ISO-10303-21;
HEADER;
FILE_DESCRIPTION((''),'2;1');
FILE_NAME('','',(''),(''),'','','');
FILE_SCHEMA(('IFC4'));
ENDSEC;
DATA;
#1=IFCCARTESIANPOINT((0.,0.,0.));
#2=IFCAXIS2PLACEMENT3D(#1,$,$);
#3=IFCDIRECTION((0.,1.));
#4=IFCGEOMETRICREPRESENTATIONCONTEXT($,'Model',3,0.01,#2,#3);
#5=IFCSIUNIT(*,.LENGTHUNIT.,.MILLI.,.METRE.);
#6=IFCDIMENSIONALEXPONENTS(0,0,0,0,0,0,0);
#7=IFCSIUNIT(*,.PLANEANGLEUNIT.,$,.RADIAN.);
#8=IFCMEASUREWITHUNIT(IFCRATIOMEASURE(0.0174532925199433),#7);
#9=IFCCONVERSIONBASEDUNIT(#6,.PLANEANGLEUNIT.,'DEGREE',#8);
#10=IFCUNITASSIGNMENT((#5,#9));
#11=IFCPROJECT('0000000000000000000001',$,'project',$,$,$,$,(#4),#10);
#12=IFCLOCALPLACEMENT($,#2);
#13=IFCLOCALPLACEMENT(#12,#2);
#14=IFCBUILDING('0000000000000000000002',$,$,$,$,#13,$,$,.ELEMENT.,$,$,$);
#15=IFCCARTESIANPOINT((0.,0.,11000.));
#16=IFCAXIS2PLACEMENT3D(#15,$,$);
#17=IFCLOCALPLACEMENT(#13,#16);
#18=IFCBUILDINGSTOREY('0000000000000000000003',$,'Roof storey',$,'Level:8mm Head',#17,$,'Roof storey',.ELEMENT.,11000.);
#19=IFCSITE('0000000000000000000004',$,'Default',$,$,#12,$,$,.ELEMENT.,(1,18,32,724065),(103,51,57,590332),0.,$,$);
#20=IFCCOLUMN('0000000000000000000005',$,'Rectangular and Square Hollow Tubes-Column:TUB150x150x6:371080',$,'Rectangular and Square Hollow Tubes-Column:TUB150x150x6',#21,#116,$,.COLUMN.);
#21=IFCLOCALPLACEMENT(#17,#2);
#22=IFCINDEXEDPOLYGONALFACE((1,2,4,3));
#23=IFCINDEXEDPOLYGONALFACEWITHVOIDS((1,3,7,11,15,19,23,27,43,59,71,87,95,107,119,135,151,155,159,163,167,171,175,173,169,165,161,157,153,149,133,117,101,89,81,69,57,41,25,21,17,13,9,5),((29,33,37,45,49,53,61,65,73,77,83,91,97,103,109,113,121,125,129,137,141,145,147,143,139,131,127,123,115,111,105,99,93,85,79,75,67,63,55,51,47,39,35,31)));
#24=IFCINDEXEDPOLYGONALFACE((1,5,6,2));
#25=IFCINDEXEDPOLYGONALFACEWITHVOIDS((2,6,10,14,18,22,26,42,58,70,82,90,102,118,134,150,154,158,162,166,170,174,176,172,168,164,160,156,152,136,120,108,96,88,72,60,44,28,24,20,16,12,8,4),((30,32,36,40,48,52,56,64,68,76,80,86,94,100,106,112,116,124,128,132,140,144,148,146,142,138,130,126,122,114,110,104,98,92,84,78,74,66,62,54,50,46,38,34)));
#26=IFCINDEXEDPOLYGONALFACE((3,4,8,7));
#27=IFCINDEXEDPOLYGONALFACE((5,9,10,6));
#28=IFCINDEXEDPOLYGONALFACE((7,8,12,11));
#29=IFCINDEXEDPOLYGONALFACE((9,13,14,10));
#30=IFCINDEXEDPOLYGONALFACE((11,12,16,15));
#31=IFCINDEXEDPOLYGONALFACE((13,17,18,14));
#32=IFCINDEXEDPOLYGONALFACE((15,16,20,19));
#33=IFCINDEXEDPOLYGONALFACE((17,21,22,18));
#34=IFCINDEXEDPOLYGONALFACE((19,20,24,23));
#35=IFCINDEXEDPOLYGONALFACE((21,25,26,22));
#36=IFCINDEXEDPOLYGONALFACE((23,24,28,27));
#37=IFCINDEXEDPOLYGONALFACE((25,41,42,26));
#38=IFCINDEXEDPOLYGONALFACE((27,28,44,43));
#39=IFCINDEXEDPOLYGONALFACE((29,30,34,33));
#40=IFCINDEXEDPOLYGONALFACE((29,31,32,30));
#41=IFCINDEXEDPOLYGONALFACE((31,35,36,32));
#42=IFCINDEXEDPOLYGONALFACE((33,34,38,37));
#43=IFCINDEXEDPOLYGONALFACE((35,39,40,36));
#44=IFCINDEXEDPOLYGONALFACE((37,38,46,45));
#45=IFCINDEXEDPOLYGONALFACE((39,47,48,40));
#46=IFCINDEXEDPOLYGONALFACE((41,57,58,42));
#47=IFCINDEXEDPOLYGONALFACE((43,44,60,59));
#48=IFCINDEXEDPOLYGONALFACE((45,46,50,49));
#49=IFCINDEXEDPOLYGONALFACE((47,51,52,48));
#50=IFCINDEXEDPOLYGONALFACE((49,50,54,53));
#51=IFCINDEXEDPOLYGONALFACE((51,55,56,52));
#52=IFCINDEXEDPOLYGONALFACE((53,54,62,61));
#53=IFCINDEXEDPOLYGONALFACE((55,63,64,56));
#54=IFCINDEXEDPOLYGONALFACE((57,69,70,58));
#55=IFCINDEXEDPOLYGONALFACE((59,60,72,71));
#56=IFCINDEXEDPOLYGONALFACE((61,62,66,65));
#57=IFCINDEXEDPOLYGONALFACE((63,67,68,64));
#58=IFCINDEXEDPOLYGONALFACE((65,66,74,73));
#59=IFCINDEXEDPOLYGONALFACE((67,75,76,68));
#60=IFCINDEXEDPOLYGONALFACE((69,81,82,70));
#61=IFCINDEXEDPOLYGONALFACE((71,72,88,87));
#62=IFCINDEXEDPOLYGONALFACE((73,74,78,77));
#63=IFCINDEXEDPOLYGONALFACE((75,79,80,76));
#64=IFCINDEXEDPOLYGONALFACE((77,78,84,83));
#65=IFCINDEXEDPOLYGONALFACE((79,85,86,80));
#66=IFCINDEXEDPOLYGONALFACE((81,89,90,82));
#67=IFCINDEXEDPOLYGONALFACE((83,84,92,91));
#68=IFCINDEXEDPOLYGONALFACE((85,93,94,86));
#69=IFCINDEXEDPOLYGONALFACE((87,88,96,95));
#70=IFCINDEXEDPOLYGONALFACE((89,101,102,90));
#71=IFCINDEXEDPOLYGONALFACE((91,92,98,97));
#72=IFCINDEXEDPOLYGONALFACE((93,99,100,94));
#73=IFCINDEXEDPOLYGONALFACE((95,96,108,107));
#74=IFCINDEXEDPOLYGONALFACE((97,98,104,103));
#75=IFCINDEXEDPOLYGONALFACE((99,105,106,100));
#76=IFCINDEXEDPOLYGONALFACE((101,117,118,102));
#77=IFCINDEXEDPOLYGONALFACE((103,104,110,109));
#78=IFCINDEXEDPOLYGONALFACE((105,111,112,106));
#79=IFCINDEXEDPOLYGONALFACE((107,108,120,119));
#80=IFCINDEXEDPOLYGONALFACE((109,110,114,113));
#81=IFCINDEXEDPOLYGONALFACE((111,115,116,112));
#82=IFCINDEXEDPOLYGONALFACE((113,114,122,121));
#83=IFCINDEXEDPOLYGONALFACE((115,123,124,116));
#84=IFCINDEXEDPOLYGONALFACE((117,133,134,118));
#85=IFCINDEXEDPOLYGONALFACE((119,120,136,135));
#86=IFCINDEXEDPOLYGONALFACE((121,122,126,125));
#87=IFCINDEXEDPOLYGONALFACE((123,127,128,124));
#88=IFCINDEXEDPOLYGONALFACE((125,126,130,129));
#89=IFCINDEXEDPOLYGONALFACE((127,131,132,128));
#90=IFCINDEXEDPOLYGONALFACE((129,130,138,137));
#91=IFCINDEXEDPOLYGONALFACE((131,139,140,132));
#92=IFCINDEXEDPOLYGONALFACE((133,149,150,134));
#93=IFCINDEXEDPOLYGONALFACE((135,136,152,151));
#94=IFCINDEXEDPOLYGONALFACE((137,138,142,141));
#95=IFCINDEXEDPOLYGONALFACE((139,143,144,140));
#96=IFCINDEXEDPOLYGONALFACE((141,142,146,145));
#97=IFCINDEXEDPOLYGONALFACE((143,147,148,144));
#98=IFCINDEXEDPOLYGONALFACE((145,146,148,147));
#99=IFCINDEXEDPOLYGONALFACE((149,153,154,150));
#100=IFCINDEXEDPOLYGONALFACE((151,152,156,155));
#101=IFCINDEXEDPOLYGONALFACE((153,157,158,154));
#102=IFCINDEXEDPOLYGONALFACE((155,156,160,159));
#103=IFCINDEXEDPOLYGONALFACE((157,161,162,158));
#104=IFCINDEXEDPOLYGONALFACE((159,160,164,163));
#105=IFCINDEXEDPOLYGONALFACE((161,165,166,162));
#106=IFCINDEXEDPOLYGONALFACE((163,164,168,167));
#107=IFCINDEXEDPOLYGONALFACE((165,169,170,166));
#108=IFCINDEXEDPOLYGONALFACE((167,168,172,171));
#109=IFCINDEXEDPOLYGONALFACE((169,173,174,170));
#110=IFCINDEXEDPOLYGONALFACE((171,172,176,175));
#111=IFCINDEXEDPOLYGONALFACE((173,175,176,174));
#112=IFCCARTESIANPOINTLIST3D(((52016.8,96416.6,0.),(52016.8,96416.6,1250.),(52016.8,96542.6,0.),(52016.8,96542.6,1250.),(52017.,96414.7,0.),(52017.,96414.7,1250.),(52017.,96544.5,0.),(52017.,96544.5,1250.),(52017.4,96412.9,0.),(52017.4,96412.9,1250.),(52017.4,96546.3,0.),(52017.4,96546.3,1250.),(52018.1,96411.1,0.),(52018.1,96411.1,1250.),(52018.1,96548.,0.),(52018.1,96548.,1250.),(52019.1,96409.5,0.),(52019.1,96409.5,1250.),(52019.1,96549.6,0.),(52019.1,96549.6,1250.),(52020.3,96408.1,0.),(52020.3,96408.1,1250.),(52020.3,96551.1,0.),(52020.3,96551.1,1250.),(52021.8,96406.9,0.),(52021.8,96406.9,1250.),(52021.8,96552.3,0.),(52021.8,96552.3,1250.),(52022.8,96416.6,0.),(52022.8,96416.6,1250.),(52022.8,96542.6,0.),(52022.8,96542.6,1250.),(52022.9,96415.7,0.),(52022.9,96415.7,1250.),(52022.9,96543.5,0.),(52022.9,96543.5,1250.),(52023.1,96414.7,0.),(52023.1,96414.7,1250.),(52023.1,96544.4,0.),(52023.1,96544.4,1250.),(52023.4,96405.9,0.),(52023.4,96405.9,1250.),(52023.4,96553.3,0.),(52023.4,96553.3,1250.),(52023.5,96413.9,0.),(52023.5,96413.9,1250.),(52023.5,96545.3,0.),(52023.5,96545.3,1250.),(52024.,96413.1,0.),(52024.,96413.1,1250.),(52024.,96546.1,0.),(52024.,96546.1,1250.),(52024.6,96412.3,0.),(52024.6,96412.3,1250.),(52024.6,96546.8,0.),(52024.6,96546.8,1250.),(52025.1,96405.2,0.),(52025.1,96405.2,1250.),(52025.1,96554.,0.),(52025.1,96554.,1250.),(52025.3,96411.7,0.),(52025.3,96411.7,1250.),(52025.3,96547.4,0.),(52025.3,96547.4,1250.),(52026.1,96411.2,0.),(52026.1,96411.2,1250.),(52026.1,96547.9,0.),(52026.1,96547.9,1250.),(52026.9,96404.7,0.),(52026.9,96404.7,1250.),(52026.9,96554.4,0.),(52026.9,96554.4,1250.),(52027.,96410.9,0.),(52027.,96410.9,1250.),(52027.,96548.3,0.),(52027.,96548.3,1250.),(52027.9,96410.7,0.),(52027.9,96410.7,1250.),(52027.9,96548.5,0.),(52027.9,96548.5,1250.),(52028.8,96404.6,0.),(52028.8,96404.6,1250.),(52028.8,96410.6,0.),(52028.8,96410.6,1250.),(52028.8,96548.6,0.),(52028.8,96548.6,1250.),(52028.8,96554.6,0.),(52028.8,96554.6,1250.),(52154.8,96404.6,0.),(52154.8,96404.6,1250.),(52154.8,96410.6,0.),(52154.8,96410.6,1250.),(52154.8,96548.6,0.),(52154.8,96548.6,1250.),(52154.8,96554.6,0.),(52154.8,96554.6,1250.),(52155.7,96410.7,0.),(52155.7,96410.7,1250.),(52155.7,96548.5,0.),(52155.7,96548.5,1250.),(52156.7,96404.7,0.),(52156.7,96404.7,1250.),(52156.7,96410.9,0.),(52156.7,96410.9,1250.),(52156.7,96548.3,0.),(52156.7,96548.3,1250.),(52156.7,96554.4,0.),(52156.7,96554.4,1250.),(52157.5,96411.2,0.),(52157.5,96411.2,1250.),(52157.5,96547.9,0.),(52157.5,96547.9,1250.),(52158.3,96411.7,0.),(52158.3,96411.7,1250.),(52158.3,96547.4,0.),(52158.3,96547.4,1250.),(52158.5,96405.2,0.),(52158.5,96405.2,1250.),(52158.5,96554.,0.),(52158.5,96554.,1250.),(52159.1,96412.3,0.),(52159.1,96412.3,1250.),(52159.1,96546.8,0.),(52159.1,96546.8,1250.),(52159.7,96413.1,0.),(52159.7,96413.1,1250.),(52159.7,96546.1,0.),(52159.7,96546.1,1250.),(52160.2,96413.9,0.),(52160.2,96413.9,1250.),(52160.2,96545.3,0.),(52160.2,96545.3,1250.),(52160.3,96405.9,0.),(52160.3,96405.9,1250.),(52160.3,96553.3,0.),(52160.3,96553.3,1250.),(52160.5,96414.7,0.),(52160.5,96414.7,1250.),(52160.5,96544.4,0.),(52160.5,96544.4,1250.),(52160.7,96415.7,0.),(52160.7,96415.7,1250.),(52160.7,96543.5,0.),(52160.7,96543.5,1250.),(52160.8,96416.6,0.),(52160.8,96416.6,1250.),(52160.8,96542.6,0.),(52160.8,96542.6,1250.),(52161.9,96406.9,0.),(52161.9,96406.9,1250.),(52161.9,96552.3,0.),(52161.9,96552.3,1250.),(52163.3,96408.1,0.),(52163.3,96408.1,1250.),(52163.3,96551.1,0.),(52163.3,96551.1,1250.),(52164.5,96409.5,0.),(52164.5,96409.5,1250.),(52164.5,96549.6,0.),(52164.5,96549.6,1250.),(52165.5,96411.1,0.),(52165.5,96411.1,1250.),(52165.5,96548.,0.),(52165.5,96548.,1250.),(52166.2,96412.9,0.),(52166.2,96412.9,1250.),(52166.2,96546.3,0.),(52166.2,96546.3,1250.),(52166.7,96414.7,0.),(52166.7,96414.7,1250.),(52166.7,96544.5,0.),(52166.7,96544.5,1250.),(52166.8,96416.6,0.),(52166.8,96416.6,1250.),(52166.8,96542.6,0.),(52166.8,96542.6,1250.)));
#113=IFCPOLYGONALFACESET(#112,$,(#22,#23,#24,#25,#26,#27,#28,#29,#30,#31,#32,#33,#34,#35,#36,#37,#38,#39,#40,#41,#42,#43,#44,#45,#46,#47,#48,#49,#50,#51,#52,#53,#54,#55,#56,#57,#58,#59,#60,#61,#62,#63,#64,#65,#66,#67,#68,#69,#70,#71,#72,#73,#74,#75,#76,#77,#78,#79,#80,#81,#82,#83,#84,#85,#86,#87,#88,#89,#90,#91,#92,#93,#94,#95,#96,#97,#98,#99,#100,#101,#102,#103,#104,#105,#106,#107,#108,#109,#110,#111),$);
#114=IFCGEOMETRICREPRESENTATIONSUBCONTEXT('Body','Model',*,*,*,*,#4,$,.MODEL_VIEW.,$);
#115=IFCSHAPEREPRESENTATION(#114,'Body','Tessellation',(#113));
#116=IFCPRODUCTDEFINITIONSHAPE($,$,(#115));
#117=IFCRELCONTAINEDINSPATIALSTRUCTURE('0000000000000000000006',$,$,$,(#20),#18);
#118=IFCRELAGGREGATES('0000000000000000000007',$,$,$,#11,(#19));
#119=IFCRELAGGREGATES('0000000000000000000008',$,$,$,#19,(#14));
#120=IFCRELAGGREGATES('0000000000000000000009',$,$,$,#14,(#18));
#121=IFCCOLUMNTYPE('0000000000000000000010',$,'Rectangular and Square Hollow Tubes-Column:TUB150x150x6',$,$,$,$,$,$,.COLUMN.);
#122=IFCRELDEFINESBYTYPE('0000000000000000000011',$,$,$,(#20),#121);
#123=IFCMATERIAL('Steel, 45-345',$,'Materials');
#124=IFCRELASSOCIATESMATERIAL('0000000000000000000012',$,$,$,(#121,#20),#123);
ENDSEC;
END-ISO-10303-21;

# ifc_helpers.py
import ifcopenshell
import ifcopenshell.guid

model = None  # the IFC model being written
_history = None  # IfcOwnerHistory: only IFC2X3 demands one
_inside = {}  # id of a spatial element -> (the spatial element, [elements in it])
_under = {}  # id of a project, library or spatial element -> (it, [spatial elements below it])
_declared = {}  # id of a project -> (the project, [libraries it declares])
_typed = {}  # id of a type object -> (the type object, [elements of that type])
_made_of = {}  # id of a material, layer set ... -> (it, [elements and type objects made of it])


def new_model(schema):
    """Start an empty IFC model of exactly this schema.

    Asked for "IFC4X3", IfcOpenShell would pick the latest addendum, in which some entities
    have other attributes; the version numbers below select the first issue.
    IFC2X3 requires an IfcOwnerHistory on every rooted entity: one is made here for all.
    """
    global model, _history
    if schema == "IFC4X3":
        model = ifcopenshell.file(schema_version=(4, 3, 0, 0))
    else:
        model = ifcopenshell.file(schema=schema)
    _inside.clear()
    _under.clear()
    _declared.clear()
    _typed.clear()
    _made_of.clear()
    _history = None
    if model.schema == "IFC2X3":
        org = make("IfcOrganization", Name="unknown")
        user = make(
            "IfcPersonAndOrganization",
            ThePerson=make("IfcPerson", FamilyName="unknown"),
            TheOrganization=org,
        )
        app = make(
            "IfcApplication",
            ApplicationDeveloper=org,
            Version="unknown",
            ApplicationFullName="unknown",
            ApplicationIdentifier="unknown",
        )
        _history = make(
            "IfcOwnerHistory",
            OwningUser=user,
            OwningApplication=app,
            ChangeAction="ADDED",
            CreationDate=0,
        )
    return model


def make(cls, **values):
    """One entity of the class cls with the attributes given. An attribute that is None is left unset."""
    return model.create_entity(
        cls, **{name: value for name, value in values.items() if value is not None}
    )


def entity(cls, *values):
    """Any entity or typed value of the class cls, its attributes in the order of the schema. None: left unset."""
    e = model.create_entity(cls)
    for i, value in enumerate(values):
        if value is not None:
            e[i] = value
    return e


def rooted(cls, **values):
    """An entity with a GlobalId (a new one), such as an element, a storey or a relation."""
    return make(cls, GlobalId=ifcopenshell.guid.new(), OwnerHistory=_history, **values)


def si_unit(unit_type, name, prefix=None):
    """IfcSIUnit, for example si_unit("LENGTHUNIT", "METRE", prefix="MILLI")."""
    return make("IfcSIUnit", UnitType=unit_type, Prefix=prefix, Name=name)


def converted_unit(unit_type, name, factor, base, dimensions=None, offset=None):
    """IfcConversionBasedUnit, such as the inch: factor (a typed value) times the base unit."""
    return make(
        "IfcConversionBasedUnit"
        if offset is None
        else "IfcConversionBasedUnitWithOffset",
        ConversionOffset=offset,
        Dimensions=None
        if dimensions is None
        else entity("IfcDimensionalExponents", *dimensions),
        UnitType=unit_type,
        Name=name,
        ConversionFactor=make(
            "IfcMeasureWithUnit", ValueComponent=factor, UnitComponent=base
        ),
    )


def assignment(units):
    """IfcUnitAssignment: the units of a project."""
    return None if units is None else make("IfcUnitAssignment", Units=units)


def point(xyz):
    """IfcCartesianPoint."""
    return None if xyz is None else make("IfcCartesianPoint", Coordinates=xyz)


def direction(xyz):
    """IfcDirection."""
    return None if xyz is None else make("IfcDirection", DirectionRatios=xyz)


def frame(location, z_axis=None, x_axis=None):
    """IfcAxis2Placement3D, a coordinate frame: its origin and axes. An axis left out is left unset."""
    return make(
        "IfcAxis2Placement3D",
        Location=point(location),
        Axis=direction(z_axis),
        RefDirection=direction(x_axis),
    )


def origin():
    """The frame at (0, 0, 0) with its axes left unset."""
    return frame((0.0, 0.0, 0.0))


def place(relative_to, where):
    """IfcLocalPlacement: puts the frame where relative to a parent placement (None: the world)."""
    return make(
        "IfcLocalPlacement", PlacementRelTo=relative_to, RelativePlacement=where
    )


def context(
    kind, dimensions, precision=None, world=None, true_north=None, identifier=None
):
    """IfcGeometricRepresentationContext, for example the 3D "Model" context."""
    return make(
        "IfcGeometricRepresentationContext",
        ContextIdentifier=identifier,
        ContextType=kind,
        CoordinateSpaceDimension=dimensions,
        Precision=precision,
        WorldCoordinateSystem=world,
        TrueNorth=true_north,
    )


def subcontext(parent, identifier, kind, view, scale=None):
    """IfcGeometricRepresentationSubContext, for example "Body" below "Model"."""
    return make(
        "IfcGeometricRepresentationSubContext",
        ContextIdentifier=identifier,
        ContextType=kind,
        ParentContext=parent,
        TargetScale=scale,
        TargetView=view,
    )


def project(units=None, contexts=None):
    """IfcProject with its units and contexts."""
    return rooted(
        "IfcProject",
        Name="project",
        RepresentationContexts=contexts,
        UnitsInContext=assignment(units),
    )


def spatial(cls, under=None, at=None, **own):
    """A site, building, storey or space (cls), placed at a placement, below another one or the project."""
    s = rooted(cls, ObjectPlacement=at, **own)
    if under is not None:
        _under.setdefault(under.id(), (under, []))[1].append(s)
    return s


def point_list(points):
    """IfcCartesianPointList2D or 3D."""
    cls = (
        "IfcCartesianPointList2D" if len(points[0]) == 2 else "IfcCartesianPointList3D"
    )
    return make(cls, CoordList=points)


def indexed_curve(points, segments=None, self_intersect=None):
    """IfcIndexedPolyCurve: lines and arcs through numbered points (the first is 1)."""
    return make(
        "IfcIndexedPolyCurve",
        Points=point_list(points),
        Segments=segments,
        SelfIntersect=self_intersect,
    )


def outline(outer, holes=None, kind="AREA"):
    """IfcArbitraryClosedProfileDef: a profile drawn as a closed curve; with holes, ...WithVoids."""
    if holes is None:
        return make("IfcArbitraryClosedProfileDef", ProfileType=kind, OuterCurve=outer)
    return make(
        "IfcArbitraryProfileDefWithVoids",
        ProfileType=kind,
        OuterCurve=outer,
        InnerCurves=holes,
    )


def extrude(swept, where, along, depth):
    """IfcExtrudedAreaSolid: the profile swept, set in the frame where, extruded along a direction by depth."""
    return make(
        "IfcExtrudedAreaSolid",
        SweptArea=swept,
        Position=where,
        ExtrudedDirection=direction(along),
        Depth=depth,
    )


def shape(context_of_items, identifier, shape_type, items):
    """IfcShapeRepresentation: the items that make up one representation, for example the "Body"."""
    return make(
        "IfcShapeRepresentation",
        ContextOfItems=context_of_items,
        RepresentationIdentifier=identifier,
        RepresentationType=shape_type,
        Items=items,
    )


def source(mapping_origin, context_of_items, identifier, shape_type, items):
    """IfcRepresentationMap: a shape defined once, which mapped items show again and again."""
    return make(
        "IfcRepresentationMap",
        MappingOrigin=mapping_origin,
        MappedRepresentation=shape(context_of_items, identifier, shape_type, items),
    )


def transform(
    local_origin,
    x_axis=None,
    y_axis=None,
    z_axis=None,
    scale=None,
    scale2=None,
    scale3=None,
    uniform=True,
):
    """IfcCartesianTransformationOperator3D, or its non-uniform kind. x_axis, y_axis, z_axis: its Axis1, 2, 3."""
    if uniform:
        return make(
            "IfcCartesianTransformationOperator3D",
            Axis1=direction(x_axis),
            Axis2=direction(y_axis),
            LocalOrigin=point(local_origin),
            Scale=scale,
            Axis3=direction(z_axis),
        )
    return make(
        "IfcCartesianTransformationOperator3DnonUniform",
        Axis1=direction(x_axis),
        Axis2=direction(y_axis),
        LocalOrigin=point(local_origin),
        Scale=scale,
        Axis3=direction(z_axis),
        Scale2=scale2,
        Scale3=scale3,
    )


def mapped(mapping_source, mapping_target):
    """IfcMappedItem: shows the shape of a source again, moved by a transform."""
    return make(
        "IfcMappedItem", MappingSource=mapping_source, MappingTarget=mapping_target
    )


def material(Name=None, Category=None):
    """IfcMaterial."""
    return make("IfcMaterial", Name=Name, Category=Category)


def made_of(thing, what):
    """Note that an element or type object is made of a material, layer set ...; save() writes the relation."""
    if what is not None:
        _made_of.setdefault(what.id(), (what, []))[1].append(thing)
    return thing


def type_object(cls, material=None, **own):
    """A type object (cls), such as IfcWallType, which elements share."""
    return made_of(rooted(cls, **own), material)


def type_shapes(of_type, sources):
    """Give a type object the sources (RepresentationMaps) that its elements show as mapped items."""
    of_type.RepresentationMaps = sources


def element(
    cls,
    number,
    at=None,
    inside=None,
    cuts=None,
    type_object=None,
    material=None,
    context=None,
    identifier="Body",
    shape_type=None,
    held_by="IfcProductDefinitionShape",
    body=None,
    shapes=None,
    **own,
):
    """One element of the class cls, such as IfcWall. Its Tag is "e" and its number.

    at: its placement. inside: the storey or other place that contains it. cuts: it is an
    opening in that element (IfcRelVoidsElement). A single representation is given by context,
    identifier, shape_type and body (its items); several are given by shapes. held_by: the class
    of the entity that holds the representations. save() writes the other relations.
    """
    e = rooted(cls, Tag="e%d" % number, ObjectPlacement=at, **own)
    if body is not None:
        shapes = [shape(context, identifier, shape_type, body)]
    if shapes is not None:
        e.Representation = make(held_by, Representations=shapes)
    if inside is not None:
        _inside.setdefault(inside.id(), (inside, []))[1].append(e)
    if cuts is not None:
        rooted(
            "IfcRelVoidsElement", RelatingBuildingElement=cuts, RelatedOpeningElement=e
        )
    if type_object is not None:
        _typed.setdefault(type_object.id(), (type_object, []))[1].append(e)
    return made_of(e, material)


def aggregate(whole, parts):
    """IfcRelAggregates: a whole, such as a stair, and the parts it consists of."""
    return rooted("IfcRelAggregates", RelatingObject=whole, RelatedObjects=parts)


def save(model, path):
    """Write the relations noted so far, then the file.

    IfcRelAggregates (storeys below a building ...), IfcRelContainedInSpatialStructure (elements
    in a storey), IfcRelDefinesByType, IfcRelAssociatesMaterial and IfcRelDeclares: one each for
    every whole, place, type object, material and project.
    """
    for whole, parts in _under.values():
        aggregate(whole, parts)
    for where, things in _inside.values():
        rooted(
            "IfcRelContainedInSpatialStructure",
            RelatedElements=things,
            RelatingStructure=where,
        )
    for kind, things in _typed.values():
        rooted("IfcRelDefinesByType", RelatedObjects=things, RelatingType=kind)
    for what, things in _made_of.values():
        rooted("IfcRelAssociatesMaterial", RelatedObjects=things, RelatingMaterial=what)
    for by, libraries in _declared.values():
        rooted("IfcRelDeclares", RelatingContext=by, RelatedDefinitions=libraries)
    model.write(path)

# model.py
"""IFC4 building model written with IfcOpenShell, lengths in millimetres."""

from ifc_helpers import new_model, entity, si_unit, converted_unit, direction, frame, origin, place, context, subcontext, project, spatial, indexed_curve, outline, extrude, source, transform, mapped, material, type_object, type_shapes, element, save


model = new_model("IFC4")

# Units and contexts
model_context = context("Model", 3, precision=0.01, world=origin(), true_north=direction((0.0, 1.0)))
body_context = subcontext(model_context, "Body", "Model", "MODEL_VIEW")
ifc_project = project(units=[si_unit("LENGTHUNIT", "METRE", prefix="MILLI"), converted_unit("PLANEANGLEUNIT", "DEGREE", entity("IfcRatioMeasure", 0.0174532925199433), si_unit("PLANEANGLEUNIT", "RADIAN"), dimensions=[0, 0, 0, 0, 0, 0, 0])], contexts=[model_context])

# Site, building, storey
site_placement = place(None, origin())
site = spatial("IfcSite", under=ifc_project, at=site_placement, Name="Default", CompositionType="ELEMENT", RefLatitude=(1, 18, 32, 724065), RefLongitude=(103, 51, 57, 590332), RefElevation=0.0)
building_placement = place(site_placement, origin())
building = spatial("IfcBuilding", under=site, at=building_placement, CompositionType="ELEMENT")
storey_placement = place(building_placement, frame((0.0, 0.0, 11000.0)))
storey = spatial("IfcBuildingStorey", under=building, at=storey_placement, Name="Roof storey", ObjectType="Level:8mm Head", LongName="Roof storey", CompositionType="ELEMENT", Elevation=11000.0)

# Column
ifc_material = material(Name="Steel, 45-345", Category="Materials")
column_type = type_object("IfcColumnType", Name="Rectangular and Square Hollow Tubes-Column:TUB150x150x6", PredefinedType="COLUMN", material=ifc_material)
shared_shape_1 = source(origin(), body_context, "Body", "SweptSolid", [
    extrude(outline(indexed_curve([(-63.0, -75.0), (63.0, -75.0), (64.9, -74.9), (66.7, -74.4), (68.4, -73.7), (70.1, -72.7), (71.5, -71.5), (72.7, -70.1), (73.7, -68.4), (74.4, -66.7), (74.9, -64.9), (75.0, -63.0), (75.0, 63.0), (74.9, 64.9), (74.4, 66.7), (73.7, 68.4), (72.7, 70.1), (71.5, 71.5), (70.1, 72.7), (68.4, 73.7), (66.7, 74.4), (64.9, 74.9), (63.0, 75.0), (-63.0, 75.0), (-64.9, 74.9), (-66.7, 74.4), (-68.4, 73.7), (-70.1, 72.7), (-71.5, 71.5), (-72.7, 70.1), (-73.7, 68.4), (-74.4, 66.7), (-74.9, 64.9), (-75.0, 63.0), (-75.0, -63.0), (-74.9, -64.9), (-74.4, -66.7), (-73.7, -68.4), (-72.7, -70.1), (-71.5, -71.5), (-70.1, -72.7), (-68.4, -73.7), (-66.7, -74.4), (-64.9, -74.9), (-63.0, -75.0)], self_intersect=False), holes=[indexed_curve([(-63.0, -69.0), (-63.9, -68.9), (-64.9, -68.7), (-65.7, -68.3), (-66.5, -67.9), (-67.2, -67.2), (-67.9, -66.5), (-68.3, -65.7), (-68.7, -64.9), (-68.9, -63.9), (-69.0, -63.0), (-69.0, 63.0), (-68.9, 63.9), (-68.7, 64.9), (-68.3, 65.7), (-67.9, 66.5), (-67.2, 67.2), (-66.5, 67.9), (-65.7, 68.3), (-64.9, 68.7), (-63.9, 68.9), (-63.0, 69.0), (63.0, 69.0), (63.9, 68.9), (64.9, 68.7), (65.7, 68.3), (66.5, 67.9), (67.2, 67.2), (67.9, 66.5), (68.3, 65.7), (68.7, 64.9), (68.9, 63.9), (69.0, 63.0), (69.0, -63.0), (68.9, -63.9), (68.7, -64.9), (68.3, -65.7), (67.9, -66.5), (67.2, -67.2), (66.5, -67.9), (65.7, -68.3), (64.9, -68.7), (63.9, -68.9), (63.0, -69.0), (-63.0, -69.0)], self_intersect=False)]), frame((0.0, 0.0, 11000.0), z_axis=(0.0, 0.0, 1.0), x_axis=(-1.0, 0.0, 0.0)), (0.0, 0.0, 1.0), 1250.0),
])
type_shapes(column_type, [shared_shape_1])
for number, where, name in (
    (1, (52091.8, 96479.6, -11000.0), "Rectangular and Square Hollow Tubes-Column:TUB150x150x6:371080"),
):
    element("IfcColumn", number, at=place(storey_placement, frame(where)), inside=storey, type_object=column_type, material=ifc_material, Name=name, ObjectType="Rectangular and Square Hollow Tubes-Column:TUB150x150x6", PredefinedType="COLUMN", context=body_context, shape_type="MappedRepresentation", body=[
        mapped(shared_shape_1, transform((0.0, 0.0, 0.0), scale=1.0)),
    ])

save(model, "model.ifc")
